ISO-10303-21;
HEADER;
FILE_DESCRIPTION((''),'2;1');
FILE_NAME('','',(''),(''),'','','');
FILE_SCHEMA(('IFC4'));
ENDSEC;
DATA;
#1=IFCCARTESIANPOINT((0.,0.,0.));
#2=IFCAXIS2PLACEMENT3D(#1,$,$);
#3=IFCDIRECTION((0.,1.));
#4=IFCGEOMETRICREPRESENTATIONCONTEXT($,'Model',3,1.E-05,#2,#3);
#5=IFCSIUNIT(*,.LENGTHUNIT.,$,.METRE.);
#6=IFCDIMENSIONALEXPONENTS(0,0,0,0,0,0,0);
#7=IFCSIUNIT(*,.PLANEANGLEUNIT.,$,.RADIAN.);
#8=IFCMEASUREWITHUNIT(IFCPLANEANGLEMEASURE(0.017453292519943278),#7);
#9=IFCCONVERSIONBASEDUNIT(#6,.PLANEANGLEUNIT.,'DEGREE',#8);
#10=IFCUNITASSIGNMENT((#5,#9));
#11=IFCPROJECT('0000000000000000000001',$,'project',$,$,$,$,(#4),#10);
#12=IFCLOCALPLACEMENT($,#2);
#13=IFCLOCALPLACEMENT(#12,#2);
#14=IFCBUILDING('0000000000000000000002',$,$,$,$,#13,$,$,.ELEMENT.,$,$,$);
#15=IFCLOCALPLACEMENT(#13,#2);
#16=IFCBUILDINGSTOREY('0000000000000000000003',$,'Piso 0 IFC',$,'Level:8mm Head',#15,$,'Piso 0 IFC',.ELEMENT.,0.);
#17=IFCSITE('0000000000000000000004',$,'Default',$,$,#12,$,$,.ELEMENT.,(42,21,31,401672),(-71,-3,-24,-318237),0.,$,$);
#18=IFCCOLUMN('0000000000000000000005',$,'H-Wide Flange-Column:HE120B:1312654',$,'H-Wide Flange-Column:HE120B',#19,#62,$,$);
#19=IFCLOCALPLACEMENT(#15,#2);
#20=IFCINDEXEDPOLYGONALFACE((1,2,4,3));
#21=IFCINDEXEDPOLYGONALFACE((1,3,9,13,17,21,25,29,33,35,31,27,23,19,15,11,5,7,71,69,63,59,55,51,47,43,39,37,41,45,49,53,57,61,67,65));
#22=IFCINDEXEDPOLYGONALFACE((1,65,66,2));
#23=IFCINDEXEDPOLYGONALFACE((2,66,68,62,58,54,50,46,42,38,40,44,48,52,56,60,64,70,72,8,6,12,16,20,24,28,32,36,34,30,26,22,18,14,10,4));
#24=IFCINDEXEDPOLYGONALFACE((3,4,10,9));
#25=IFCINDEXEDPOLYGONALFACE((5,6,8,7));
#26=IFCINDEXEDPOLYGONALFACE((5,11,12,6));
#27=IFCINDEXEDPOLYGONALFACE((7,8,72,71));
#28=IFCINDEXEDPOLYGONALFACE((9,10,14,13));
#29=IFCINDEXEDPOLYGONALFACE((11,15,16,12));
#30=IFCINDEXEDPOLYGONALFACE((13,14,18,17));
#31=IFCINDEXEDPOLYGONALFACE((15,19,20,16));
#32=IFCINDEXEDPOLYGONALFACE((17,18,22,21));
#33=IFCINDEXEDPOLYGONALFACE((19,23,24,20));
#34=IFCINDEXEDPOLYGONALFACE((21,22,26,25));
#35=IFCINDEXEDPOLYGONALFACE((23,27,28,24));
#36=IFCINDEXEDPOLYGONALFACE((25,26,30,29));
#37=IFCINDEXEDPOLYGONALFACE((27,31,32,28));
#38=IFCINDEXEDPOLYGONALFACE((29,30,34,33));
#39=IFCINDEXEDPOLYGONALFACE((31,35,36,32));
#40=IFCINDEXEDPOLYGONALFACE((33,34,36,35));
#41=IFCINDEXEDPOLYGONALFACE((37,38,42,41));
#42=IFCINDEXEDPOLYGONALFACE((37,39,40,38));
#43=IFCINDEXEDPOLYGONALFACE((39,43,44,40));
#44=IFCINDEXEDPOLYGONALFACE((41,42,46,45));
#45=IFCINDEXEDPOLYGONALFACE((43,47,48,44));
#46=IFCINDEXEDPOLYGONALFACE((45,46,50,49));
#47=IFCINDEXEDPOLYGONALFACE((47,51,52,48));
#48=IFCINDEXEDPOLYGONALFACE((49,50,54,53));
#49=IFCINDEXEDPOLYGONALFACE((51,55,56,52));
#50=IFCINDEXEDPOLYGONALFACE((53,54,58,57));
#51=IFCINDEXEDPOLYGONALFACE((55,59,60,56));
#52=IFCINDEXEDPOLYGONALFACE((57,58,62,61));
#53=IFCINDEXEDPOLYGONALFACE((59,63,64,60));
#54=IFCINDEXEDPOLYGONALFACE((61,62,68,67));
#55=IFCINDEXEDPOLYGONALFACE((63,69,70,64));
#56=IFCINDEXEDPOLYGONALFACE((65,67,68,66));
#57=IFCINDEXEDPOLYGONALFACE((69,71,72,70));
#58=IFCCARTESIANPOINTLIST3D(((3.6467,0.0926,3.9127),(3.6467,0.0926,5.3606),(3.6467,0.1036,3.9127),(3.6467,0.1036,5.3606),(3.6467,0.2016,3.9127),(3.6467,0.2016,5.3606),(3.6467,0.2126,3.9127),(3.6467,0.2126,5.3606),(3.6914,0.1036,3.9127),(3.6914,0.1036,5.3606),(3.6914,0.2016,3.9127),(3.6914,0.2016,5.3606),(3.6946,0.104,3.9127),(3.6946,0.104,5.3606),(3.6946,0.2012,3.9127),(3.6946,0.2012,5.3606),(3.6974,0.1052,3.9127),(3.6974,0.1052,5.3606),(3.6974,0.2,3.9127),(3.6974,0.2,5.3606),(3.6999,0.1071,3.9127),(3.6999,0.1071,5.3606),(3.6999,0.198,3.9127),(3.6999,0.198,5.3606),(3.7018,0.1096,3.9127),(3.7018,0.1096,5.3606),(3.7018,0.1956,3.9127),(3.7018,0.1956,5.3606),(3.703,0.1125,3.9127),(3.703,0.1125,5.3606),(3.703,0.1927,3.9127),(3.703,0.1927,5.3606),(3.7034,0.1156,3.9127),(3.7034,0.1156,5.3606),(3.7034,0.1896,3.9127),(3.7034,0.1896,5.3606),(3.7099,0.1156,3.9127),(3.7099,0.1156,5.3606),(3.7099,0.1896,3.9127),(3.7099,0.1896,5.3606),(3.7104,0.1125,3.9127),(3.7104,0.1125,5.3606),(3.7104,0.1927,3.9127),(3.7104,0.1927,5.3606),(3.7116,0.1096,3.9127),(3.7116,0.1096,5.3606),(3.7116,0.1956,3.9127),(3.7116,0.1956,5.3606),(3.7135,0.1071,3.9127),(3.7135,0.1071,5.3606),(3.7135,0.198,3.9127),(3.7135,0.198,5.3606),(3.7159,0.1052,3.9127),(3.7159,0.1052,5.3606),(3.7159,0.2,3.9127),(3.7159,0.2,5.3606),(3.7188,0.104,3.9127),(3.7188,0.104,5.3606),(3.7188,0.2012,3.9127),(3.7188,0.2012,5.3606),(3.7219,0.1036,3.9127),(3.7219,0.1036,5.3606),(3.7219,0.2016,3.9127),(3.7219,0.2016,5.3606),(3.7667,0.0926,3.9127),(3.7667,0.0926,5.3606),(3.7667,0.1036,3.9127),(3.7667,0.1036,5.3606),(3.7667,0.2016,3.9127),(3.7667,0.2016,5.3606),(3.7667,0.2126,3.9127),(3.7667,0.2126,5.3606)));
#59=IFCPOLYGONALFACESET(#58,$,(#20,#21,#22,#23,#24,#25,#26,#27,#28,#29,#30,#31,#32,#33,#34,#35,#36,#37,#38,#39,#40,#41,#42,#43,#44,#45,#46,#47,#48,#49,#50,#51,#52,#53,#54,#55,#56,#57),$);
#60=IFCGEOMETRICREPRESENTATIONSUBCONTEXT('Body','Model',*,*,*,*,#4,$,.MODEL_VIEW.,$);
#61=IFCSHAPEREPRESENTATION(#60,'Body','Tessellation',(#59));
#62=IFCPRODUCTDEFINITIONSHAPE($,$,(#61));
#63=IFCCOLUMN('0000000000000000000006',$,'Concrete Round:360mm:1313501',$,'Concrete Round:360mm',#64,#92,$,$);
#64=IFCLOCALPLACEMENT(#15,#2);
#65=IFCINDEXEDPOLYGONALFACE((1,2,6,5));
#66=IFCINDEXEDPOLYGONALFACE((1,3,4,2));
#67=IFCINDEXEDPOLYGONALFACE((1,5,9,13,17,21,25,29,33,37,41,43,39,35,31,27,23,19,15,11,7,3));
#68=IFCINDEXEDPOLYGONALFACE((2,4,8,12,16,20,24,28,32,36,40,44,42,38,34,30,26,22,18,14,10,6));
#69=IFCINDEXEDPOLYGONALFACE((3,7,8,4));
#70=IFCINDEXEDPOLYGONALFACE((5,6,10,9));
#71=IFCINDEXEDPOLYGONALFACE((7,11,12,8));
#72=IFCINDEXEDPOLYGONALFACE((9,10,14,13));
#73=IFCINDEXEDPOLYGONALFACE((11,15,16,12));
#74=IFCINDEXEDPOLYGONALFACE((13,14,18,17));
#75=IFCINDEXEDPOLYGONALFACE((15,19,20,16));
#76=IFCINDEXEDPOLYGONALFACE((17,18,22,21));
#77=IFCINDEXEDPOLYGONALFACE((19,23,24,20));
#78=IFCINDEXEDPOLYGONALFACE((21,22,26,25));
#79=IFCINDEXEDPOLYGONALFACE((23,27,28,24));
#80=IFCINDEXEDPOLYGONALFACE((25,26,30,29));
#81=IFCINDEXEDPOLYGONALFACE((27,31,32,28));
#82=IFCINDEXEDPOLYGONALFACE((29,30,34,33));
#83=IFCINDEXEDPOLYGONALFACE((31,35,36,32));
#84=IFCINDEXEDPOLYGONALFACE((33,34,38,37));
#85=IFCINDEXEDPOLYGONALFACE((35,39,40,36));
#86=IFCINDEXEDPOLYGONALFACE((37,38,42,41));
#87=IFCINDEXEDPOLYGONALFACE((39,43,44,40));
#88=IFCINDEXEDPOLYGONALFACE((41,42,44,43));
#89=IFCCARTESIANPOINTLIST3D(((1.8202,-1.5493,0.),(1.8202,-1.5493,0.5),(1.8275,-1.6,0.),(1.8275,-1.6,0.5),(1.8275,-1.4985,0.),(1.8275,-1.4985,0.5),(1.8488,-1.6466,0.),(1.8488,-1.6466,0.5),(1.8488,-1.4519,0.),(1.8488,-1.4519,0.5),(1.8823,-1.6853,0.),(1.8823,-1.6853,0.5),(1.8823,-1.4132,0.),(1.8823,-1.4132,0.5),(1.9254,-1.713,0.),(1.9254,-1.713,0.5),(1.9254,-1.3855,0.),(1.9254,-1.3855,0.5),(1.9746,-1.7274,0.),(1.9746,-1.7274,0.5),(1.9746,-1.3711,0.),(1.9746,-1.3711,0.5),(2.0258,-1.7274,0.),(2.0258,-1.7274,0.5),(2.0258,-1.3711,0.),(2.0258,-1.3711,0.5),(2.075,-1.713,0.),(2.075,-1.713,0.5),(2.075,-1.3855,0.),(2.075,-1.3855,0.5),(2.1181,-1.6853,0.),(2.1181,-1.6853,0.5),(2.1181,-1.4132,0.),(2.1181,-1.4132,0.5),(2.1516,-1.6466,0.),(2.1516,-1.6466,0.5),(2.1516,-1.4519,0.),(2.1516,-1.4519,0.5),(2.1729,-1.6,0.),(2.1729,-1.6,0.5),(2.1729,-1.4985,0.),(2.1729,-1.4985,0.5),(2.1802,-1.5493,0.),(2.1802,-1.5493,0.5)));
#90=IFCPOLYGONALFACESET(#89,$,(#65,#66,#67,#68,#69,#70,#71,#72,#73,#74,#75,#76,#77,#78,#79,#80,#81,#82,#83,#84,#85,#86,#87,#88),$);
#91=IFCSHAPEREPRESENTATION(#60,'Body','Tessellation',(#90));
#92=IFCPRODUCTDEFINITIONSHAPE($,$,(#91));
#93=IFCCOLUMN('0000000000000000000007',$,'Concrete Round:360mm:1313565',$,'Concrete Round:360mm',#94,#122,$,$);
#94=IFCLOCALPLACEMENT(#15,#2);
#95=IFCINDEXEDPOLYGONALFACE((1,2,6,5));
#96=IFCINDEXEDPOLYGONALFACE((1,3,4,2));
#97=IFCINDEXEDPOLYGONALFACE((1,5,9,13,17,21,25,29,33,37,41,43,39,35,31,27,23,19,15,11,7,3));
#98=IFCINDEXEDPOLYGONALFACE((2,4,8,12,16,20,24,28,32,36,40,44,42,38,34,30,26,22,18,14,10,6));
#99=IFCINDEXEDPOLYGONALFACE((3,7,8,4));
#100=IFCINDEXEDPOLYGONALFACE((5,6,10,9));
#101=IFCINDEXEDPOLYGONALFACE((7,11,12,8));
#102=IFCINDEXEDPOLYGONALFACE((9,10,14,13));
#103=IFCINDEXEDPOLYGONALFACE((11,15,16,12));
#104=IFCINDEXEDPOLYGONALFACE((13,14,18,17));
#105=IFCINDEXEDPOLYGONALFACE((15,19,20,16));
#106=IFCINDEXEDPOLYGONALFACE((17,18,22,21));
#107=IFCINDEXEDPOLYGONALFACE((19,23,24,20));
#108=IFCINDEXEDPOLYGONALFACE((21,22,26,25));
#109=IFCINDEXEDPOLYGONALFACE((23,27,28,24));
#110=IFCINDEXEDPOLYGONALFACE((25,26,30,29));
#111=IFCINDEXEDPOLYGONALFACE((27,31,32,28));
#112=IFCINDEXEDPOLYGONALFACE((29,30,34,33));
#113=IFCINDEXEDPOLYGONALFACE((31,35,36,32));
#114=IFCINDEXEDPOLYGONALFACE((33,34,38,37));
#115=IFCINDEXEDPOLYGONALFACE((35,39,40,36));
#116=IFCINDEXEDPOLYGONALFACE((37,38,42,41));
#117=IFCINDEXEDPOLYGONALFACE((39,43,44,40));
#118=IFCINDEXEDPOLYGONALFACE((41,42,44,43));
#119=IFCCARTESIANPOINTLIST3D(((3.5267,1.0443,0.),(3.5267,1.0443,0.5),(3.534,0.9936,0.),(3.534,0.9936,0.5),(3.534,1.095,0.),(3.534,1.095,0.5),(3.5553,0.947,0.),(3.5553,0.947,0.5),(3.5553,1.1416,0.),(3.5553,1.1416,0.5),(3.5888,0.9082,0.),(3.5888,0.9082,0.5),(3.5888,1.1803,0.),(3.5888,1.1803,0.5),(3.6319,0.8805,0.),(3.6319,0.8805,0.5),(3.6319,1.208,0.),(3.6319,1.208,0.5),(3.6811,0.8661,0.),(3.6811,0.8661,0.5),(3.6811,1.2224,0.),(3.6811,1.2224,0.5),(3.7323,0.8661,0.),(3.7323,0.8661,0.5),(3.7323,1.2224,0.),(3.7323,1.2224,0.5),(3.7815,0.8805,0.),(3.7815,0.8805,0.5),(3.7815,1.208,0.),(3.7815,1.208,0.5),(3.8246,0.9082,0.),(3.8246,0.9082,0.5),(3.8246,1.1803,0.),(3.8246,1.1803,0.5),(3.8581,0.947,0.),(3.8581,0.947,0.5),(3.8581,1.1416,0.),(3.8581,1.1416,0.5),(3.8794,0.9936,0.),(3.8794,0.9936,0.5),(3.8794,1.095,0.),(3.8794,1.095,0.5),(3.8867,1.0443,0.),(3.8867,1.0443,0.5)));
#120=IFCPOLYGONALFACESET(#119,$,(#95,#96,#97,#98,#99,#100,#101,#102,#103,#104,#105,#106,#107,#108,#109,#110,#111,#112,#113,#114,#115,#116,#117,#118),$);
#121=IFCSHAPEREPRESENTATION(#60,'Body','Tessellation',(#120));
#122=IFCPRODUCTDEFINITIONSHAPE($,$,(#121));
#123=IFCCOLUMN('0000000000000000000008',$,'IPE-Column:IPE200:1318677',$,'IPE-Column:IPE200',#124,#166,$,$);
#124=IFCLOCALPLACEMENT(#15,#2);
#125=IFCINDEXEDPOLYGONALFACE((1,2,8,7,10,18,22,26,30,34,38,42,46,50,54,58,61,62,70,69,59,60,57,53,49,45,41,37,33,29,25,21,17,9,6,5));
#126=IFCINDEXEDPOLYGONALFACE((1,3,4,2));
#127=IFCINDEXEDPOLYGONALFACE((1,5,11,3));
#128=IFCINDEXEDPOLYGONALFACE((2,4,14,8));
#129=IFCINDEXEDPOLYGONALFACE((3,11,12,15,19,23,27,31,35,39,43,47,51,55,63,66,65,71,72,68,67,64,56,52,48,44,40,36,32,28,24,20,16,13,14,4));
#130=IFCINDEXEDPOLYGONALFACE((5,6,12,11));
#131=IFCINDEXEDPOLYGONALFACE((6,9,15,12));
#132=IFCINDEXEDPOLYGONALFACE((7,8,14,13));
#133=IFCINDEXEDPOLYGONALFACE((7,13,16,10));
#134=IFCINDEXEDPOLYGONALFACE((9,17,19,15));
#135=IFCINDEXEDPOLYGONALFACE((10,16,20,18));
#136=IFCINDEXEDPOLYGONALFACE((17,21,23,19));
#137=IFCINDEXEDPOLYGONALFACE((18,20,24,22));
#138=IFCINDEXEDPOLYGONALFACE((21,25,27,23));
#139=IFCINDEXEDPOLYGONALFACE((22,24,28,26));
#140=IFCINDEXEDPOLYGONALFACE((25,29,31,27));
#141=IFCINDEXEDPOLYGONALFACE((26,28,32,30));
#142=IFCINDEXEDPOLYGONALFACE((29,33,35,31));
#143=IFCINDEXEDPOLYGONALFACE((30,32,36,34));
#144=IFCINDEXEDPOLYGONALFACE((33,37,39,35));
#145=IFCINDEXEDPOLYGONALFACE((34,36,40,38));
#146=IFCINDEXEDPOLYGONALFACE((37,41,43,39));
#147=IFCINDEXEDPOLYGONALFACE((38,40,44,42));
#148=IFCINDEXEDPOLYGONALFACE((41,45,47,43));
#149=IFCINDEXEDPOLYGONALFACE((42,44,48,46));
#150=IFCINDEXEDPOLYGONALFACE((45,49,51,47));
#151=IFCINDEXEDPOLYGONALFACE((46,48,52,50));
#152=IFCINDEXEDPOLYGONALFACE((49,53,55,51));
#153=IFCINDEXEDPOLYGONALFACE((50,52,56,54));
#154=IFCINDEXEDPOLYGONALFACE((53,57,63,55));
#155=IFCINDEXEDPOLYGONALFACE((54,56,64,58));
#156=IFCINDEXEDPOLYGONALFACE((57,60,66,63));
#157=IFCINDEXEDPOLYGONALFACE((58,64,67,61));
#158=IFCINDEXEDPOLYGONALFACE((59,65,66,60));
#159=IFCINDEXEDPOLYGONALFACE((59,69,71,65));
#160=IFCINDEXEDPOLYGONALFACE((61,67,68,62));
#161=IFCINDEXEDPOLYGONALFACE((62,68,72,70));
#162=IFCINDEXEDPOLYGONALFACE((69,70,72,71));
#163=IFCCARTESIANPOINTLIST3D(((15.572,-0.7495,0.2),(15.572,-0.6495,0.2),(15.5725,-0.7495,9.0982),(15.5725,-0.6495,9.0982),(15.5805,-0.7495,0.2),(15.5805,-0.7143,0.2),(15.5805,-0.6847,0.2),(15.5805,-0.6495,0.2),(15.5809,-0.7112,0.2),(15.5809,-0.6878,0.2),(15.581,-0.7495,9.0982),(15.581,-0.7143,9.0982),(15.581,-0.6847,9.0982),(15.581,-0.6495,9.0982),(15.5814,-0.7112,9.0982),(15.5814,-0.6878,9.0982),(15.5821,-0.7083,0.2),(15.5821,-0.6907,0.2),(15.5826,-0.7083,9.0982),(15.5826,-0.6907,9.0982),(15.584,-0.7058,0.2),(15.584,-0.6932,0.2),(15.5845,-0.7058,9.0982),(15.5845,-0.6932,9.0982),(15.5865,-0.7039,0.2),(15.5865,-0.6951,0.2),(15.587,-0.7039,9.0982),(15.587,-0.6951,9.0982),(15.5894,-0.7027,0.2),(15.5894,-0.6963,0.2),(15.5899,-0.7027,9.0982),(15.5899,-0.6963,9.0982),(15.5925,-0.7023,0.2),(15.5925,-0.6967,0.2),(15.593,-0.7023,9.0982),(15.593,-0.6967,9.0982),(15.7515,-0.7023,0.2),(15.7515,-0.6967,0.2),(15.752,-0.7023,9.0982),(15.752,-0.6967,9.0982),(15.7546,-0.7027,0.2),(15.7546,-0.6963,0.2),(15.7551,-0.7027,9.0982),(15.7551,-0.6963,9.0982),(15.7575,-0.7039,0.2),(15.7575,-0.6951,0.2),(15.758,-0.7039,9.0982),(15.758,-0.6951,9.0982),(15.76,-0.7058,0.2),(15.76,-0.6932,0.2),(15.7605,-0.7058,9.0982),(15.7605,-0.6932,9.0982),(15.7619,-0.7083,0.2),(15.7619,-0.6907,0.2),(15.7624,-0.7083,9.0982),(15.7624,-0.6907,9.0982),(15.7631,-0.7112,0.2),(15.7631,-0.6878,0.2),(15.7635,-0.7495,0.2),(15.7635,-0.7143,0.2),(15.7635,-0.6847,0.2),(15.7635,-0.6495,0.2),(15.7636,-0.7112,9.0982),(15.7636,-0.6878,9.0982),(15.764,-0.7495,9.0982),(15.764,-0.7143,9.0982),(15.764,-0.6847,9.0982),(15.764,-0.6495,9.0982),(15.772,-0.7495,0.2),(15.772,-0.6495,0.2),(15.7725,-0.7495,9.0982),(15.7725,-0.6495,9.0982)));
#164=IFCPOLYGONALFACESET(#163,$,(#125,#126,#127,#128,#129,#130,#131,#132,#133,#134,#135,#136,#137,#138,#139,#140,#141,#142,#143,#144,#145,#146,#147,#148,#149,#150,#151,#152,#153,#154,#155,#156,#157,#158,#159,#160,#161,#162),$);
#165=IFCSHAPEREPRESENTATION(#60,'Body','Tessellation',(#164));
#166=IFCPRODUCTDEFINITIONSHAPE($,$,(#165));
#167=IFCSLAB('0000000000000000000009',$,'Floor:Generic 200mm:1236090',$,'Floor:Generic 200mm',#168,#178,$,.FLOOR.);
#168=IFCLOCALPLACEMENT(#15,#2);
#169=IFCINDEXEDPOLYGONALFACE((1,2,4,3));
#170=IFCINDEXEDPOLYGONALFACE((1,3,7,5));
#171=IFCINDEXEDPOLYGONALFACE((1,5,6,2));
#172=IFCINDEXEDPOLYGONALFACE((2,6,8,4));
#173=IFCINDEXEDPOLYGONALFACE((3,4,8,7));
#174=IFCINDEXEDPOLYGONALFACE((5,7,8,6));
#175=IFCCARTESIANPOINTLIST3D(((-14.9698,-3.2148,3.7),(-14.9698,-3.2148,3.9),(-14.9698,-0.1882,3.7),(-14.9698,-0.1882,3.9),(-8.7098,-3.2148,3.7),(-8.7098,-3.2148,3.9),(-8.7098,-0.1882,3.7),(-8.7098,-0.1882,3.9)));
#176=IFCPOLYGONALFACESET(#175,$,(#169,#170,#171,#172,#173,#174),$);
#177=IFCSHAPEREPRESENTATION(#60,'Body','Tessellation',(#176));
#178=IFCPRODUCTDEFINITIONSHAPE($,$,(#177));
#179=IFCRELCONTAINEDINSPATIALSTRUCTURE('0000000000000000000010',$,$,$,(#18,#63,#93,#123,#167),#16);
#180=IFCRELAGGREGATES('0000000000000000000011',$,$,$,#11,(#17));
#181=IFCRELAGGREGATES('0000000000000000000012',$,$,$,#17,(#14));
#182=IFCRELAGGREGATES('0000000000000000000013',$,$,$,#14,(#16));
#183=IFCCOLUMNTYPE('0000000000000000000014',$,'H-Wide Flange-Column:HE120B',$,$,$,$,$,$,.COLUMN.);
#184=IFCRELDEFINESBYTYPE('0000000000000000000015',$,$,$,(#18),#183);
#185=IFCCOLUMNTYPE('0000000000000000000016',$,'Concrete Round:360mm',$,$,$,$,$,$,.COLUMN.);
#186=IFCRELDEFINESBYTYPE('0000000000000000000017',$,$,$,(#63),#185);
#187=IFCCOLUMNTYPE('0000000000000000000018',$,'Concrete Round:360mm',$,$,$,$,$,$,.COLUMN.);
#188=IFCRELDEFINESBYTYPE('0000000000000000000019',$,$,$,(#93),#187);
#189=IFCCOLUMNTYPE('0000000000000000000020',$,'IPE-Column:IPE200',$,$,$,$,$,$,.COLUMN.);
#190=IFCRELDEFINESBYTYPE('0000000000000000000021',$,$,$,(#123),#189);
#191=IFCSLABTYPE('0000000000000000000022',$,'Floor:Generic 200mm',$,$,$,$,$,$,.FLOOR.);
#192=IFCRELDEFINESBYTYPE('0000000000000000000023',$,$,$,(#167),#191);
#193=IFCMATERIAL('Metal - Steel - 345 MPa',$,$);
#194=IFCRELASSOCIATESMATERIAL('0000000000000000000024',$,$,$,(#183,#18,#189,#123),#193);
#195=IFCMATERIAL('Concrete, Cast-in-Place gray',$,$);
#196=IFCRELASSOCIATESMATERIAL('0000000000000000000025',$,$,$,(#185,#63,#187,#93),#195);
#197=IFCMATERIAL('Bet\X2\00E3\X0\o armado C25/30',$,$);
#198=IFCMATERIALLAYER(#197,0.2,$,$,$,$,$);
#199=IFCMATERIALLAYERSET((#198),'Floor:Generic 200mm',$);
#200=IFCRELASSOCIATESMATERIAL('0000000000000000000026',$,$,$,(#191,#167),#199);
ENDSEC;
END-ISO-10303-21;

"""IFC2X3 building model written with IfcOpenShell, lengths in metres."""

from ifc_helpers import new_model, entity, si_unit, converted_unit, direction, frame, frame_2d, origin, origin_2d_with_axis, place, context, subcontext, project, spatial, rectangle, circle, i_section, extrude, source, transform, mapped, material, layer, layer_set, layer_usage, type_object, type_shapes, element, save


model = new_model("IFC2X3")

# Units and contexts
model_context = context("Model", 3, precision=1e-05, world=origin(), true_north=direction((0.0, 1.0)))
body_context = subcontext(model_context, "Body", "Model", "MODEL_VIEW")
ifc_project = project(units=[si_unit("LENGTHUNIT", "METRE"), converted_unit("PLANEANGLEUNIT", "DEGREE", entity("IfcPlaneAngleMeasure", 0.017453292519943278), si_unit("PLANEANGLEUNIT", "RADIAN"), dimensions=[0, 0, 0, 0, 0, 0, 0])], contexts=[model_context])

# Site, building, storey
site_placement = place(None, origin())
site = spatial("IfcSite", under=ifc_project, at=site_placement, Name="Default", CompositionType="ELEMENT", RefLatitude=(42, 21, 31, 401672), RefLongitude=(-71, -3, -24, -318237), RefElevation=0.0)
building_placement = place(site_placement, origin())
building = spatial("IfcBuilding", under=site, at=building_placement, CompositionType="ELEMENT")
storey_placement = place(building_placement, origin())
storey = spatial("IfcBuildingStorey", under=building, at=storey_placement, Name="Piso 0 IFC", ObjectType="Level:8mm Head", LongName="Piso 0 IFC", CompositionType="ELEMENT", Elevation=0.0)

# Columns
ifc_material_1 = material(Name="Metal - Steel - 345 MPa")
ifc_material_2 = material(Name="Concrete, Cast-in-Place gray")
column_type_1 = type_object("IfcColumnType", Name="H-Wide Flange-Column:HE120B", PredefinedType="COLUMN", material=ifc_material_1)
shared_shape_1 = source(origin(), body_context, "Body", "SweptSolid", [
    extrude(i_section(OverallWidth=0.12, OverallDepth=0.12, WebThickness=0.0065, FlangeThickness=0.011, FilletRadius=0.012, at=frame_2d((0.0, 0.0), x_axis=(0.0, 1.0))), frame((3.7067, 0.1526, 3.9127), z_axis=(0.0, 0.0, 1.0), x_axis=(0.0, -1.0, 0.0)), (0.0, 0.0, 1.0), 1.4479),
])
type_shapes(column_type_1, [shared_shape_1])
column_1_placement = place(storey_placement, origin())
element("IfcColumn", 1, at=column_1_placement, inside=storey, type_object=column_type_1, material=ifc_material_1, Name="H-Wide Flange-Column:HE120B:1312654", ObjectType="H-Wide Flange-Column:HE120B", context=body_context, shape_type="MappedRepresentation", body=[
    mapped(shared_shape_1, transform((0.0, 0.0, 0.0), scale=1.0)),
])
column_type_2 = type_object("IfcColumnType", Name="Concrete Round:360mm", PredefinedType="COLUMN", material=ifc_material_2)
shared_shape_2 = source(origin(), body_context, "Body", "SweptSolid", [
    extrude(circle(Radius=0.18, at=frame_2d((0.0, 0.0), x_axis=(1.0, 0.0))), frame((2.0002, -1.5493, 0.0)), (0.0, 0.0, 1.0), 0.5),
])
type_shapes(column_type_2, [shared_shape_2])
column_2_placement = place(storey_placement, origin())
element("IfcColumn", 2, at=column_2_placement, inside=storey, type_object=column_type_2, material=ifc_material_2, Name="Concrete Round:360mm:1313501", ObjectType="Concrete Round:360mm", context=body_context, shape_type="MappedRepresentation", body=[
    mapped(shared_shape_2, transform((0.0, 0.0, 0.0), scale=1.0)),
])
column_type_3 = type_object("IfcColumnType", Name="Concrete Round:360mm", PredefinedType="COLUMN", material=ifc_material_2)
shared_shape_3 = source(origin(), body_context, "Body", "SweptSolid", [
    extrude(circle(Radius=0.18, at=frame_2d((0.0, 0.0), x_axis=(1.0, 0.0))), frame((3.7067, 1.0443, 0.0)), (0.0, 0.0, 1.0), 0.5),
])
type_shapes(column_type_3, [shared_shape_3])
column_3_placement = place(storey_placement, origin())
element("IfcColumn", 3, at=column_3_placement, inside=storey, type_object=column_type_3, material=ifc_material_2, Name="Concrete Round:360mm:1313565", ObjectType="Concrete Round:360mm", context=body_context, shape_type="MappedRepresentation", body=[
    mapped(shared_shape_3, transform((0.0, 0.0, 0.0), scale=1.0)),
])
column_type_4 = type_object("IfcColumnType", Name="IPE-Column:IPE200", PredefinedType="COLUMN", material=ifc_material_1)
shared_shape_4 = source(origin(), body_context, "Body", "SweptSolid", [
    extrude(i_section(OverallWidth=0.1, OverallDepth=0.2, WebThickness=0.0056, FlangeThickness=0.0085, FilletRadius=0.012, at=origin_2d_with_axis()), frame((15.672, -0.6995, 0.2), z_axis=(0.000055, 0.0, 1.0), x_axis=(0.0, -1.0, 0.0)), (0.0, 0.0, 1.0), 8.8982),
])
type_shapes(column_type_4, [shared_shape_4])
column_4_placement = place(storey_placement, origin())
element("IfcColumn", 4, at=column_4_placement, inside=storey, type_object=column_type_4, material=ifc_material_1, Name="IPE-Column:IPE200:1318677", ObjectType="IPE-Column:IPE200", context=body_context, shape_type="MappedRepresentation", body=[
    mapped(shared_shape_4, transform((0.0, 0.0, 0.0), scale=1.0)),
])

# Slab
ifc_material_3 = material(Name="Betão armado C25/30")
ifc_layer_1 = layer(ifc_material_3, 0.2)
ifc_layer_set_1 = layer_set([ifc_layer_1], Name="Floor:Generic 200mm")
slab_type_1 = type_object("IfcSlabType", Name="Floor:Generic 200mm", PredefinedType="FLOOR", material=ifc_layer_set_1)
ifc_layer_usage_1 = layer_usage(ifc_layer_set_1, "AXIS3", "POSITIVE", 0.0)
slab_1_placement = place(storey_placement, origin())
element("IfcSlab", 5, at=slab_1_placement, inside=storey, type_object=slab_type_1, material=ifc_layer_usage_1, Name="Floor:Generic 200mm:1236090", ObjectType="Floor:Generic 200mm", PredefinedType="FLOOR", context=body_context, shape_type="SweptSolid", body=[
    extrude(rectangle(XDim=3.0266, YDim=6.26, at=frame_2d((0.0, 0.0), x_axis=(1.0, 0.0))), frame((-11.8398, -1.7015, 3.9), z_axis=(0.0, 0.0, -1.0), x_axis=(0.0, 1.0, 0.0)), (0.0, 0.0, 1.0), 0.2),
])

save(model, "model.ifc")
